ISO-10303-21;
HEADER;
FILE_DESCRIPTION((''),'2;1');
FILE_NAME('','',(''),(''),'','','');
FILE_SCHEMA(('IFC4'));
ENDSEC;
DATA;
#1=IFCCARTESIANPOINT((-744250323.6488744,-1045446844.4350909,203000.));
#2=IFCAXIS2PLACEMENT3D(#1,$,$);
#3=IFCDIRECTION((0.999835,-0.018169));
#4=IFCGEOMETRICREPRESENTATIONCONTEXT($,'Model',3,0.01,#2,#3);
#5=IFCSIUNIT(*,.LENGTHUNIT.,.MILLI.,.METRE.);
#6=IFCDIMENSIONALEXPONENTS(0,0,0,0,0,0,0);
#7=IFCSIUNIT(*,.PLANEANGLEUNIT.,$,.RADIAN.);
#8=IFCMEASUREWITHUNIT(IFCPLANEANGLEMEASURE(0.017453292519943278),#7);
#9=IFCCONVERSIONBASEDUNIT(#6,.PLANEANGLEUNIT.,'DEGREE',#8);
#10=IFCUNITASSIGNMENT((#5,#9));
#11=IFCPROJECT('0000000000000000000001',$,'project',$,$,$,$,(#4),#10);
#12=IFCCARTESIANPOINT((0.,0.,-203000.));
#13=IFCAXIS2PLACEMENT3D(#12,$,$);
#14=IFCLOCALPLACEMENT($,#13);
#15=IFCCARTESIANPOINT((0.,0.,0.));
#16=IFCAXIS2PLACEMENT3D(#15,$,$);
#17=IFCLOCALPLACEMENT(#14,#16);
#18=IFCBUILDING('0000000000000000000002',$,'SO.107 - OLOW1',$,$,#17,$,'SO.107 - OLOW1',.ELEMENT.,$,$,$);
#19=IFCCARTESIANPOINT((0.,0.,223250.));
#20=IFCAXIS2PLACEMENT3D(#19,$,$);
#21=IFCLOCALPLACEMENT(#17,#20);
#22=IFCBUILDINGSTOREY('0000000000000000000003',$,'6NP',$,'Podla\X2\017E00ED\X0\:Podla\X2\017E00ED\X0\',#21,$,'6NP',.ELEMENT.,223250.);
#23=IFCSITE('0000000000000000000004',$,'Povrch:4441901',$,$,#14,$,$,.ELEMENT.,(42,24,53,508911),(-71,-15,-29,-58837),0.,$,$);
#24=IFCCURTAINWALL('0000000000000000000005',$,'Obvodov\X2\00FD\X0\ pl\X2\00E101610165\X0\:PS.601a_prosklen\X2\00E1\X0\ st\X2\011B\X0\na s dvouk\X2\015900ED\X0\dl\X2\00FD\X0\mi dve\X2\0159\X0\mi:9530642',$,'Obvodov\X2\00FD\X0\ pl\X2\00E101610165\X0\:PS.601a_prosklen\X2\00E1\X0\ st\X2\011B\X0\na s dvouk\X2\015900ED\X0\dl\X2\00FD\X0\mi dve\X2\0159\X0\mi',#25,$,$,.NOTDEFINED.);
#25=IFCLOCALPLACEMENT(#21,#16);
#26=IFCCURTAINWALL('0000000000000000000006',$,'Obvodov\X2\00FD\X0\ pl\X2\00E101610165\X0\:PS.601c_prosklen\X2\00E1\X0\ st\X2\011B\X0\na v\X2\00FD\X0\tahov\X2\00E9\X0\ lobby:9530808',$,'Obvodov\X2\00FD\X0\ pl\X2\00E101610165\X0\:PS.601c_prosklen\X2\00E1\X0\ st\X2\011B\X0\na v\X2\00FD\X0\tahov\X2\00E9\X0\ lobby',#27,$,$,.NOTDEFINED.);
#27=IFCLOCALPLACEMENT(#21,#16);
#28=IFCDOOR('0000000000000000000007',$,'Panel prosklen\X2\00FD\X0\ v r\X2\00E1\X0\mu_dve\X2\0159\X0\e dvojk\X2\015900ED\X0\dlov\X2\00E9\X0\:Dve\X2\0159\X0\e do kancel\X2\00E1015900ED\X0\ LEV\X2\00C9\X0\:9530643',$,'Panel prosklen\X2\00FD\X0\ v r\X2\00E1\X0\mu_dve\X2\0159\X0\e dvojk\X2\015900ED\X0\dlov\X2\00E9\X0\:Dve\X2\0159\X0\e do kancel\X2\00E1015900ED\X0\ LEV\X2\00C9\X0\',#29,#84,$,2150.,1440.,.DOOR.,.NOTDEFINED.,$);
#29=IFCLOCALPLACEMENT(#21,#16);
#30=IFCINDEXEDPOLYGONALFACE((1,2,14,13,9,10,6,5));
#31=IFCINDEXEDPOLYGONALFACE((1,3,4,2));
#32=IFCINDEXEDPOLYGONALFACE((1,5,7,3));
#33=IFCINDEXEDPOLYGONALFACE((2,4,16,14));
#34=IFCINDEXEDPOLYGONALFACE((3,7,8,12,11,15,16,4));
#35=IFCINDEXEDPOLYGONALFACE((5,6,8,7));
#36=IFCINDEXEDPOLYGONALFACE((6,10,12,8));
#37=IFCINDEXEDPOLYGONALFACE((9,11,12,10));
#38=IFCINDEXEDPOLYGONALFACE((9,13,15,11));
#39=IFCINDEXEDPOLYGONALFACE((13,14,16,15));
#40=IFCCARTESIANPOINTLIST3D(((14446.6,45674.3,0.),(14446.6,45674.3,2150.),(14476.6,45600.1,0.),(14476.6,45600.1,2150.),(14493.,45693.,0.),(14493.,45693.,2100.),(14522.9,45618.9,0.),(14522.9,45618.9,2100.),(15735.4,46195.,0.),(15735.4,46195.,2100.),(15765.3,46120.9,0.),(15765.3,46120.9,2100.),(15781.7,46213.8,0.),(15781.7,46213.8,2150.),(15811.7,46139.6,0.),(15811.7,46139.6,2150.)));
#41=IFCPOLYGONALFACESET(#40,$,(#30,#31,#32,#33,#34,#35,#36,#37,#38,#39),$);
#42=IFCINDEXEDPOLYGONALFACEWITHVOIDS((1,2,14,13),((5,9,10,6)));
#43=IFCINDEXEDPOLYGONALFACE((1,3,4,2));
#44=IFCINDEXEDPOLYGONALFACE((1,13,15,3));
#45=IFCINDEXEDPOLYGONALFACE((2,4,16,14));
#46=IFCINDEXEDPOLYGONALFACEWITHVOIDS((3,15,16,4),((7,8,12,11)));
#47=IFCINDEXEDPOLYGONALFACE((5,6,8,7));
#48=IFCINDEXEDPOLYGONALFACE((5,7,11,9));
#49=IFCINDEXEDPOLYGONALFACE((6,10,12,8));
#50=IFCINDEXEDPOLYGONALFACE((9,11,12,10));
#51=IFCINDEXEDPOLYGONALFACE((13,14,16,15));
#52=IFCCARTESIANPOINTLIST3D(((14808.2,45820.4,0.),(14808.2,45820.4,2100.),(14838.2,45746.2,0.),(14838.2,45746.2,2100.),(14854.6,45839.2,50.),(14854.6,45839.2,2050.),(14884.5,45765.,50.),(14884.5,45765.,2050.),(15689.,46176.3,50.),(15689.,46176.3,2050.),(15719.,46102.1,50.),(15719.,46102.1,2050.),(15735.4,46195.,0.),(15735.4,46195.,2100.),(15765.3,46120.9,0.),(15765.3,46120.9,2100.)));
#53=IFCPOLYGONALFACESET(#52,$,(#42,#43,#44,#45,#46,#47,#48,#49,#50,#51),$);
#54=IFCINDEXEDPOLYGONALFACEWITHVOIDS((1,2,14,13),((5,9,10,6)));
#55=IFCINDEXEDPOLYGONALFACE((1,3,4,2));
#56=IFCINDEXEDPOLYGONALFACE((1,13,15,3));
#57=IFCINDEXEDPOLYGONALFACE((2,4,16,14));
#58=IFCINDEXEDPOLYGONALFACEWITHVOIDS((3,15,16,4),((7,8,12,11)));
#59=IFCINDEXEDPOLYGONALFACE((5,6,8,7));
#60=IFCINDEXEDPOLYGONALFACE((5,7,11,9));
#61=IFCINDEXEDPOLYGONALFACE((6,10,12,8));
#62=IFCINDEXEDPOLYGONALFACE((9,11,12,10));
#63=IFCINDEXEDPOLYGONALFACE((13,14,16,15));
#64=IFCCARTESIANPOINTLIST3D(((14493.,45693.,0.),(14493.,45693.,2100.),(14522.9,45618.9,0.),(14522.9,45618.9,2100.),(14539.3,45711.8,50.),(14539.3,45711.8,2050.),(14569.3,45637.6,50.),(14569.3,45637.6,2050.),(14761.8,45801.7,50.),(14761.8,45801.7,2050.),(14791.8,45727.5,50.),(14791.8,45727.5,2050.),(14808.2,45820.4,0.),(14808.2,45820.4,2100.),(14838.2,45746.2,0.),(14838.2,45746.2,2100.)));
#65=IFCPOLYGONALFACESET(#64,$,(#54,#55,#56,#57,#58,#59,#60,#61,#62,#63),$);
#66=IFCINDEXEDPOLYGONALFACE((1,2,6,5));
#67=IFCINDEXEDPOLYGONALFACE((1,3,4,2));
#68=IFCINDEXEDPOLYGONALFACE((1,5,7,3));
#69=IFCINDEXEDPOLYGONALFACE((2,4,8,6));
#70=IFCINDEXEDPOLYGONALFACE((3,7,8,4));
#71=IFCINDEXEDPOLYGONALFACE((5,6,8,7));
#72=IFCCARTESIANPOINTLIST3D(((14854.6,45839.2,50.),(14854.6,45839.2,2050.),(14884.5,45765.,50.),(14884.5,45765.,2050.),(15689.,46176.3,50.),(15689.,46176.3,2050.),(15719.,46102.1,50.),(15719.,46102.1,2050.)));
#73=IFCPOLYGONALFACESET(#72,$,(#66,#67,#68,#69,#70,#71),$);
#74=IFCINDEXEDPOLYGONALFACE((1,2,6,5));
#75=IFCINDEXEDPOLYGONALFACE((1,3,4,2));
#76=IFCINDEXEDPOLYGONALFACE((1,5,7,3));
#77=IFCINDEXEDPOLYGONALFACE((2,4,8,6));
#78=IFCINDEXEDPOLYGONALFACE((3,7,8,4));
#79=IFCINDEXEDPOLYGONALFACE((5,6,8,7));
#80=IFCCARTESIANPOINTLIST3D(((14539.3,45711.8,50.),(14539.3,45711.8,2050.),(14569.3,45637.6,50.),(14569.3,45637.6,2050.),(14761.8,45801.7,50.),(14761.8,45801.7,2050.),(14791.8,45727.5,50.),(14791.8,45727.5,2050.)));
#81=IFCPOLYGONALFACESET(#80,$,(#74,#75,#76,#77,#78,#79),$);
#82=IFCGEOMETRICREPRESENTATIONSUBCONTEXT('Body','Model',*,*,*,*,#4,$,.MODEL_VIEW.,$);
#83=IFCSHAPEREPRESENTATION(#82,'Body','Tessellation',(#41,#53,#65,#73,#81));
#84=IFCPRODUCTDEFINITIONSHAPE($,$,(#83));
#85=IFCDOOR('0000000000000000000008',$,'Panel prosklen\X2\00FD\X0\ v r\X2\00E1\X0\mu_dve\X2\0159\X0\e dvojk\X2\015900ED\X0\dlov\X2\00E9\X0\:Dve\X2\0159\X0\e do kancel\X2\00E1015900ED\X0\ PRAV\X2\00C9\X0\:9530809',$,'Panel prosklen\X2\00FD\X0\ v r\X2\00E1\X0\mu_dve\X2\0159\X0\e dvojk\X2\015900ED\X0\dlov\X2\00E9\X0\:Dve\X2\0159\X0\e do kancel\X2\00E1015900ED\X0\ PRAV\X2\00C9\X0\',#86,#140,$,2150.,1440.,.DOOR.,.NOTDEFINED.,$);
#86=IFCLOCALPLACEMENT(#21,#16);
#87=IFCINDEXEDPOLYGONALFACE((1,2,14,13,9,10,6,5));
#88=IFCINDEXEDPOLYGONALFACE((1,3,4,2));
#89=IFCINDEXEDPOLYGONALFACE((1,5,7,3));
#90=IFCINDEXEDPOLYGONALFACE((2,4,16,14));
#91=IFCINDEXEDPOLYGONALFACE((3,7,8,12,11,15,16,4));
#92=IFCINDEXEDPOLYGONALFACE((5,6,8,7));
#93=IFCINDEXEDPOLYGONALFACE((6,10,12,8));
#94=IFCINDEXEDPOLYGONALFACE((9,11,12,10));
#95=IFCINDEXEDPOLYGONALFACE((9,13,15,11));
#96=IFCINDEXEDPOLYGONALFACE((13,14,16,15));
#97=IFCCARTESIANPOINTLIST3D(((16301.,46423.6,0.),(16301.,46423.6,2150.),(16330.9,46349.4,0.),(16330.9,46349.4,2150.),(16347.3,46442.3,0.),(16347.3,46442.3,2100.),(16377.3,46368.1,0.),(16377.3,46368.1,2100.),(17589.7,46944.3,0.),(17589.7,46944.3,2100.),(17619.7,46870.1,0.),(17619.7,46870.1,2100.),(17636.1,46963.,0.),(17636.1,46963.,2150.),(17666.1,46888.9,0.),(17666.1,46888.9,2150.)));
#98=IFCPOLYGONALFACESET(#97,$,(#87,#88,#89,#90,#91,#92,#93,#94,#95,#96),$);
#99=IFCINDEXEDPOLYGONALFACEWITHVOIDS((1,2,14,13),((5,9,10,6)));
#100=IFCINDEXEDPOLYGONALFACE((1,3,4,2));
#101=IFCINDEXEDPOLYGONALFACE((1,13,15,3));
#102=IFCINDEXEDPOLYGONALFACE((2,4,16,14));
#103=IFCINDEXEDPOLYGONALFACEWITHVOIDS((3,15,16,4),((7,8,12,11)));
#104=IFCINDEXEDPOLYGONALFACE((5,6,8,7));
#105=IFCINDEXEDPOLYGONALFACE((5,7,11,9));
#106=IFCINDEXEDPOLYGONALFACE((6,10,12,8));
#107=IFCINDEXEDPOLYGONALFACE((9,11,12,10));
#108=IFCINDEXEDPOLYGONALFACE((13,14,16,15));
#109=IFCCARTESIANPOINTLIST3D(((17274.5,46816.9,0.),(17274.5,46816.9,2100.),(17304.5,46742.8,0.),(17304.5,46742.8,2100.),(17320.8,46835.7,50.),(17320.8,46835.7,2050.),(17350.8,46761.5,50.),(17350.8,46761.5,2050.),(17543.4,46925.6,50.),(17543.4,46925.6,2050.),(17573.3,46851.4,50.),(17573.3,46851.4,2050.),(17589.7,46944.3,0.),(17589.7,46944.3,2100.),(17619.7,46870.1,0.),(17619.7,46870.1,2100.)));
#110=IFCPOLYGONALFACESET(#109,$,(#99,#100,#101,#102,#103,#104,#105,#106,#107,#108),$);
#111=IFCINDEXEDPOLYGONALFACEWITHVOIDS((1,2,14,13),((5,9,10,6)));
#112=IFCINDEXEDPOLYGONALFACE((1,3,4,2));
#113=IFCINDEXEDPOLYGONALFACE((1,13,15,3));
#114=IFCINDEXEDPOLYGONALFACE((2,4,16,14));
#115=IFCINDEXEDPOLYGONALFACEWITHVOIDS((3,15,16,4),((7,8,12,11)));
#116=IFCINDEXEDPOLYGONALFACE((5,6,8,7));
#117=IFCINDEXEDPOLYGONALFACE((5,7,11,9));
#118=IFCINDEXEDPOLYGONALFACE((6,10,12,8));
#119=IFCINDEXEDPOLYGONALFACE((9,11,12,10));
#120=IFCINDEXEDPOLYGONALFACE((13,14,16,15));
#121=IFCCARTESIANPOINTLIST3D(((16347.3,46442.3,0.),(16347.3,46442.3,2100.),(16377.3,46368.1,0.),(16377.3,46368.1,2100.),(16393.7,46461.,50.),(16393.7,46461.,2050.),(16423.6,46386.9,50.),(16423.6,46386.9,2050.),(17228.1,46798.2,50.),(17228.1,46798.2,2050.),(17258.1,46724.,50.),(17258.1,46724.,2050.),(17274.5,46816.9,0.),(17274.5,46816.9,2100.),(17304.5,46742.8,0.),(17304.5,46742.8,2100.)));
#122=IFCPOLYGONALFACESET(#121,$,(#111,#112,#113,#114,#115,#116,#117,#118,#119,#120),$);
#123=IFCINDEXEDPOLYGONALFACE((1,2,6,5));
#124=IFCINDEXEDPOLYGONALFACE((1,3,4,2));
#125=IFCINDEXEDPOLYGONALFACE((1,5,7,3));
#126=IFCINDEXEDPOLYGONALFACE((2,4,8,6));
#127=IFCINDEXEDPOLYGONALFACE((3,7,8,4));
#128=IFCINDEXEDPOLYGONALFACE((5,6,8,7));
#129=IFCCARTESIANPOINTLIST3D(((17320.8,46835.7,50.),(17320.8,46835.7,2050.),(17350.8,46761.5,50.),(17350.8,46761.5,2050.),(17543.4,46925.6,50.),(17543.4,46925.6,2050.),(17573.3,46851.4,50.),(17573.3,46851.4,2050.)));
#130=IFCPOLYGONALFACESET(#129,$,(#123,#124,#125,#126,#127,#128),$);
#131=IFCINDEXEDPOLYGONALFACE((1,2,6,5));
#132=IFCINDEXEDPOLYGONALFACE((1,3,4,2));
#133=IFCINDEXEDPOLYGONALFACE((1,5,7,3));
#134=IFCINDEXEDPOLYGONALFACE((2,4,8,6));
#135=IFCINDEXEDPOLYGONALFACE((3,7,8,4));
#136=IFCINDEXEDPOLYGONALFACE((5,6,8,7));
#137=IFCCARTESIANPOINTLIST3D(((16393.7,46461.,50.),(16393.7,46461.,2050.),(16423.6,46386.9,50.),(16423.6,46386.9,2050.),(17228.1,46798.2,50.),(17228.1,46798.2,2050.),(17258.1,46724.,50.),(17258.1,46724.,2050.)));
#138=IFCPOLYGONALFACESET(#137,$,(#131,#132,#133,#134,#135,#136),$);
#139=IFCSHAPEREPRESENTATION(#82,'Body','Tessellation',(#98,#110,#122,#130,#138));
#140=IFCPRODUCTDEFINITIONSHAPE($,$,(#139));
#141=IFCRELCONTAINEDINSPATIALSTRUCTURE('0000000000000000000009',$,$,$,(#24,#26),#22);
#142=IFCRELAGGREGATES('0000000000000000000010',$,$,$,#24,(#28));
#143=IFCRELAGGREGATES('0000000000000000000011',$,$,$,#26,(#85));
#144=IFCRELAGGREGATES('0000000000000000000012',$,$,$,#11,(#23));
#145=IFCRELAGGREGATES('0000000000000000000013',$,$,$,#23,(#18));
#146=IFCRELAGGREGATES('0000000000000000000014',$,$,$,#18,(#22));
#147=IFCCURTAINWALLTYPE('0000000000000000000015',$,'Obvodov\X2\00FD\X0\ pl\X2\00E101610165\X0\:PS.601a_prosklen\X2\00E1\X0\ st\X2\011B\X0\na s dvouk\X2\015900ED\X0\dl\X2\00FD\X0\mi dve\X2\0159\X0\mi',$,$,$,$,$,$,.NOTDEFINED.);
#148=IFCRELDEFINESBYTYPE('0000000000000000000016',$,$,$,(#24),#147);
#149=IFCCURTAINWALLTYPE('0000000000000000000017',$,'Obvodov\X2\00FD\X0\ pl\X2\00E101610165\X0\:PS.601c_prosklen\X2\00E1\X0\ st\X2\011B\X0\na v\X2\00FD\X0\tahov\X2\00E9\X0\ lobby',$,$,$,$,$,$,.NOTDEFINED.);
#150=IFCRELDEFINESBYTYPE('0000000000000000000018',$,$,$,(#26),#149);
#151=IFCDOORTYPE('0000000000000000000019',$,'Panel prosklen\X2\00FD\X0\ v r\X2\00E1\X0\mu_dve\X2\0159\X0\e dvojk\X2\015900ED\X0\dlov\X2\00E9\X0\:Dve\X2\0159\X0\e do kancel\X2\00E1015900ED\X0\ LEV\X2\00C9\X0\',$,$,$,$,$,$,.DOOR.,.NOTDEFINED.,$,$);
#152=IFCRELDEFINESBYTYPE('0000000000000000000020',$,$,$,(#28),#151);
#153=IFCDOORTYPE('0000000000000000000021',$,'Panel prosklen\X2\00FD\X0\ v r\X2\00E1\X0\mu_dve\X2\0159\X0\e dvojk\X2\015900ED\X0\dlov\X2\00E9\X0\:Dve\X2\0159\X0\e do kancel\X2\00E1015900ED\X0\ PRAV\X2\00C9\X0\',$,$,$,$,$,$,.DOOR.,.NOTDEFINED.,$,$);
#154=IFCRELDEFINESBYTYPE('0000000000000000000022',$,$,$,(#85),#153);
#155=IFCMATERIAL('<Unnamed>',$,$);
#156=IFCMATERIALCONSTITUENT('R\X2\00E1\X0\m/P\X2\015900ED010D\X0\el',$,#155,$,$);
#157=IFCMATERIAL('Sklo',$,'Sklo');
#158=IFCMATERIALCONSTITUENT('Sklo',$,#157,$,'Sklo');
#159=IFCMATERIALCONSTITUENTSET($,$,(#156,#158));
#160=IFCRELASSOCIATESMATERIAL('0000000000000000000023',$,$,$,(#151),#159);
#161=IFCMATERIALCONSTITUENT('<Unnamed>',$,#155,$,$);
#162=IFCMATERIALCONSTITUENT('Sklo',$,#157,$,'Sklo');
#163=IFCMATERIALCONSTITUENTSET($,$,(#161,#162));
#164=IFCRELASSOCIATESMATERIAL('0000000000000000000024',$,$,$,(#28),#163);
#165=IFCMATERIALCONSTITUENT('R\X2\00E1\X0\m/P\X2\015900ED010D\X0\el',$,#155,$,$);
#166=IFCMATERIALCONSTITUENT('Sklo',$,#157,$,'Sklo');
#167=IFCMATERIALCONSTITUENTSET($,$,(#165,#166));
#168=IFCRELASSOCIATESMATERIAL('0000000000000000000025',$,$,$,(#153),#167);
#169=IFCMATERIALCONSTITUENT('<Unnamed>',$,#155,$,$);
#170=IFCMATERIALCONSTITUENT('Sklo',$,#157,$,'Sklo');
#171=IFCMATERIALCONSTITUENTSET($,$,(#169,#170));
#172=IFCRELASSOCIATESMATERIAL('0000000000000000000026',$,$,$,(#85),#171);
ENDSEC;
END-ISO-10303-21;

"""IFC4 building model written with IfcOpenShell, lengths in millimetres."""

from ifc_helpers import new_model, entity, si_unit, converted_unit, direction, frame, origin, place, context, subcontext, project, spatial, indexed_curve, outline, extrude, source, transform, mapped, material, constituent, constituent_set, type_object, type_shapes, element, aggregate, save


model = new_model("IFC4")

# Units and contexts
model_context = context("Model", 3, precision=0.01, world=frame((-744250323.6488744, -1045446844.4350909, 203000.0)), true_north=direction((0.999835, -0.018169)))
body_context = subcontext(model_context, "Body", "Model", "MODEL_VIEW")
ifc_project = project(units=[si_unit("LENGTHUNIT", "METRE", prefix="MILLI"), converted_unit("PLANEANGLEUNIT", "DEGREE", entity("IfcPlaneAngleMeasure", 0.017453292519943278), si_unit("PLANEANGLEUNIT", "RADIAN"), dimensions=[0, 0, 0, 0, 0, 0, 0])], contexts=[model_context])

# Site, building, storey
site_placement = place(None, frame((0.0, 0.0, -203000.0)))
site = spatial("IfcSite", under=ifc_project, at=site_placement, Name="Povrch:4441901", CompositionType="ELEMENT", RefLatitude=(42, 24, 53, 508911), RefLongitude=(-71, -15, -29, -58837), RefElevation=0.0)
building_placement = place(site_placement, origin())
building = spatial("IfcBuilding", under=site, at=building_placement, Name="SO.107 - OLOW1", LongName="SO.107 - OLOW1", CompositionType="ELEMENT")
storey_placement = place(building_placement, frame((0.0, 0.0, 223250.0)))
storey = spatial("IfcBuildingStorey", under=building, at=storey_placement, Name="6NP", ObjectType="Podlaží:Podlaží", LongName="6NP", CompositionType="ELEMENT", Elevation=223250.0)

# Curtain walls
curtain_wall_type_1 = type_object("IfcCurtainWallType", Name="Obvodový plášť:PS.601a_prosklená stěna s dvoukřídlými dveřmi", PredefinedType="NOTDEFINED")
curtain_wall_1_placement = place(storey_placement, frame((0.0, 0.0, -223250.0)))
curtain_wall_1 = element("IfcCurtainWall", 1, at=curtain_wall_1_placement, inside=storey, type_object=curtain_wall_type_1, Name="Obvodový plášť:PS.601a_prosklená stěna s dvoukřídlými dveřmi:9530642", ObjectType="Obvodový plášť:PS.601a_prosklená stěna s dvoukřídlými dveřmi", PredefinedType="NOTDEFINED")
ifc_material_1 = material(Name="<Unnamed>")
curtain_wall_type_2 = type_object("IfcCurtainWallType", Name="Obvodový plášť:PS.601c_prosklená stěna výtahové lobby", PredefinedType="NOTDEFINED")
curtain_wall_2_placement = place(storey_placement, frame((0.0, 0.0, -223250.0)))
curtain_wall_2 = element("IfcCurtainWall", 2, at=curtain_wall_2_placement, inside=storey, type_object=curtain_wall_type_2, Name="Obvodový plášť:PS.601c_prosklená stěna výtahové lobby:9530808", ObjectType="Obvodový plášť:PS.601c_prosklená stěna výtahové lobby", PredefinedType="NOTDEFINED")

# Shared definitions
ifc_material_2 = material(Name="Sklo", Category="Sklo")

# Doors
ifc_constituent_1 = constituent(ifc_material_1, Name="<Unnamed>")
ifc_constituent_2 = constituent(ifc_material_2, Name="Sklo", Category="Sklo")
ifc_constituent_set_1 = constituent_set(constituents=[ifc_constituent_1, ifc_constituent_2])
ifc_constituent_3 = constituent(ifc_material_1, Name="Rám/Příčel")
ifc_constituent_4 = constituent(ifc_material_2, Name="Sklo", Category="Sklo")
ifc_constituent_set_2 = constituent_set(constituents=[ifc_constituent_3, ifc_constituent_4])
door_type_1 = type_object("IfcDoorType", Name="Panel prosklený v rámu_dveře dvojkřídlové:Dveře do kanceláří LEVÉ", OperationType="NOTDEFINED", PredefinedType="DOOR", material=ifc_constituent_set_2)
shared_shape_1 = source(origin(), body_context, "Body", "SweptSolid", [
    extrude(outline(indexed_curve([(-720.0, -1087.5), (720.0, -1087.5), (720.0, 1062.5), (670.0, 1062.5), (670.0, -1037.5), (-670.0, -1037.5), (-670.0, 1062.5), (-720.0, 1062.5), (-720.0, -1087.5)], self_intersect=False)), frame((0.0, 40.0, 1062.5), z_axis=(0.0, -1.0, 0.0), x_axis=(-1.0, 0.0, 0.0)), (0.0, 0.0, 1.0), 80.0),
    extrude(outline(indexed_curve([(-1050.0, -500.0), (1050.0, -500.0), (1050.0, 500.0), (-1050.0, 500.0), (-1050.0, -500.0)], self_intersect=False), holes=[indexed_curve([(-1000.0, -450.0), (-1000.0, 450.0), (1000.0, 450.0), (1000.0, -450.0), (-1000.0, -450.0)], self_intersect=False)]), frame((-170.0, 40.0, 1050.0), z_axis=(0.0, -1.0, 0.0), x_axis=(0.0, 0.0, -1.0)), (0.0, 0.0, 1.0), 80.0),
    extrude(outline(indexed_curve([(-1050.0, -170.0), (1050.0, -170.0), (1050.0, 170.0), (-1050.0, 170.0), (-1050.0, -170.0)], self_intersect=False), holes=[indexed_curve([(-1000.0, -120.0), (-1000.0, 120.0), (1000.0, 120.0), (1000.0, -120.0), (-1000.0, -120.0)], self_intersect=False)]), frame((500.0, 40.0, 1050.0), z_axis=(0.0, -1.0, 0.0), x_axis=(0.0, 0.0, -1.0)), (0.0, 0.0, 1.0), 80.0),
    extrude(outline(indexed_curve([(-450.0, -40.0), (450.0, -40.0), (450.0, 40.0), (-450.0, 40.0), (-450.0, -40.0)], self_intersect=False)), frame((-170.0, 0.0, 50.0)), (0.0, 0.0, 1.0), 2000.0),
    extrude(outline(indexed_curve([(-120.0, -40.0), (120.0, -40.0), (120.0, 40.0), (-120.0, 40.0), (-120.0, -40.0)], self_intersect=False)), frame((500.0, 0.0, 50.0)), (0.0, 0.0, 1.0), 2000.0),
])
type_shapes(door_type_1, [shared_shape_1])
door_1_placement = place(curtain_wall_1_placement, frame((15129.2, 45907.0, 223250.0), z_axis=(0.0, 0.0, 1.0), x_axis=(-0.927176, -0.374626, 0.0)))
door_1 = element("IfcDoor", 3, at=door_1_placement, type_object=door_type_1, material=ifc_constituent_set_1, Name="Panel prosklený v rámu_dveře dvojkřídlové:Dveře do kanceláří LEVÉ:9530643", ObjectType="Panel prosklený v rámu_dveře dvojkřídlové:Dveře do kanceláří LEVÉ", OperationType="NOTDEFINED", OverallHeight=2150.0, OverallWidth=1440.0, PredefinedType="DOOR", context=body_context, shape_type="MappedRepresentation", body=[
    mapped(shared_shape_1, transform((0.0, 0.0, 0.0), scale=1.0)),
])
aggregate(curtain_wall_1, [door_1])
ifc_constituent_5 = constituent(ifc_material_1, Name="<Unnamed>")
ifc_constituent_6 = constituent(ifc_material_2, Name="Sklo", Category="Sklo")
ifc_constituent_set_3 = constituent_set(constituents=[ifc_constituent_5, ifc_constituent_6])
ifc_constituent_7 = constituent(ifc_material_1, Name="Rám/Příčel")
ifc_constituent_8 = constituent(ifc_material_2, Name="Sklo", Category="Sklo")
ifc_constituent_set_4 = constituent_set(constituents=[ifc_constituent_7, ifc_constituent_8])
door_type_2 = type_object("IfcDoorType", Name="Panel prosklený v rámu_dveře dvojkřídlové:Dveře do kanceláří PRAVÉ", OperationType="NOTDEFINED", PredefinedType="DOOR", material=ifc_constituent_set_4)
shared_shape_2 = source(origin(), body_context, "Body", "SweptSolid", [
    extrude(outline(indexed_curve([(-720.0, -1087.5), (720.0, -1087.5), (720.0, 1062.5), (670.0, 1062.5), (670.0, -1037.5), (-670.0, -1037.5), (-670.0, 1062.5), (-720.0, 1062.5), (-720.0, -1087.5)], self_intersect=False)), frame((0.0, 40.0, 1062.5), z_axis=(0.0, -1.0, 0.0), x_axis=(-1.0, 0.0, 0.0)), (0.0, 0.0, 1.0), 80.0),
    extrude(outline(indexed_curve([(-1050.0, -170.0), (1050.0, -170.0), (1050.0, 170.0), (-1050.0, 170.0), (-1050.0, -170.0)], self_intersect=False), holes=[indexed_curve([(-1000.0, -120.0), (-1000.0, 120.0), (1000.0, 120.0), (1000.0, -120.0), (-1000.0, -120.0)], self_intersect=False)]), frame((-500.0, 40.0, 1050.0), z_axis=(0.0, -1.0, 0.0), x_axis=(0.0, 0.0, -1.0)), (0.0, 0.0, 1.0), 80.0),
    extrude(outline(indexed_curve([(-1050.0, -500.0), (1050.0, -500.0), (1050.0, 500.0), (-1050.0, 500.0), (-1050.0, -500.0)], self_intersect=False), holes=[indexed_curve([(-1000.0, -450.0), (-1000.0, 450.0), (1000.0, 450.0), (1000.0, -450.0), (-1000.0, -450.0)], self_intersect=False)]), frame((170.0, 40.0, 1050.0), z_axis=(0.0, -1.0, 0.0), x_axis=(0.0, 0.0, -1.0)), (0.0, 0.0, 1.0), 80.0),
    extrude(outline(indexed_curve([(-120.0, -40.0), (120.0, -40.0), (120.0, 40.0), (-120.0, 40.0), (-120.0, -40.0)], self_intersect=False)), frame((-500.0, 0.0, 50.0)), (0.0, 0.0, 1.0), 2000.0),
    extrude(outline(indexed_curve([(-450.0, -40.0), (450.0, -40.0), (450.0, 40.0), (-450.0, 40.0), (-450.0, -40.0)], self_intersect=False)), frame((170.0, 0.0, 50.0)), (0.0, 0.0, 1.0), 2000.0),
])
type_shapes(door_type_2, [shared_shape_2])
door_2_placement = place(curtain_wall_2_placement, frame((16983.5, 46656.2, 223250.0), z_axis=(0.0, 0.0, 1.0), x_axis=(-0.927176, -0.374626, 0.0)))
door_2 = element("IfcDoor", 4, at=door_2_placement, type_object=door_type_2, material=ifc_constituent_set_3, Name="Panel prosklený v rámu_dveře dvojkřídlové:Dveře do kanceláří PRAVÉ:9530809", ObjectType="Panel prosklený v rámu_dveře dvojkřídlové:Dveře do kanceláří PRAVÉ", OperationType="NOTDEFINED", OverallHeight=2150.0, OverallWidth=1440.0, PredefinedType="DOOR", context=body_context, shape_type="MappedRepresentation", body=[
    mapped(shared_shape_2, transform((0.0, 0.0, 0.0), scale=1.0)),
])
aggregate(curtain_wall_2, [door_2])

save(model, "model.ifc")
